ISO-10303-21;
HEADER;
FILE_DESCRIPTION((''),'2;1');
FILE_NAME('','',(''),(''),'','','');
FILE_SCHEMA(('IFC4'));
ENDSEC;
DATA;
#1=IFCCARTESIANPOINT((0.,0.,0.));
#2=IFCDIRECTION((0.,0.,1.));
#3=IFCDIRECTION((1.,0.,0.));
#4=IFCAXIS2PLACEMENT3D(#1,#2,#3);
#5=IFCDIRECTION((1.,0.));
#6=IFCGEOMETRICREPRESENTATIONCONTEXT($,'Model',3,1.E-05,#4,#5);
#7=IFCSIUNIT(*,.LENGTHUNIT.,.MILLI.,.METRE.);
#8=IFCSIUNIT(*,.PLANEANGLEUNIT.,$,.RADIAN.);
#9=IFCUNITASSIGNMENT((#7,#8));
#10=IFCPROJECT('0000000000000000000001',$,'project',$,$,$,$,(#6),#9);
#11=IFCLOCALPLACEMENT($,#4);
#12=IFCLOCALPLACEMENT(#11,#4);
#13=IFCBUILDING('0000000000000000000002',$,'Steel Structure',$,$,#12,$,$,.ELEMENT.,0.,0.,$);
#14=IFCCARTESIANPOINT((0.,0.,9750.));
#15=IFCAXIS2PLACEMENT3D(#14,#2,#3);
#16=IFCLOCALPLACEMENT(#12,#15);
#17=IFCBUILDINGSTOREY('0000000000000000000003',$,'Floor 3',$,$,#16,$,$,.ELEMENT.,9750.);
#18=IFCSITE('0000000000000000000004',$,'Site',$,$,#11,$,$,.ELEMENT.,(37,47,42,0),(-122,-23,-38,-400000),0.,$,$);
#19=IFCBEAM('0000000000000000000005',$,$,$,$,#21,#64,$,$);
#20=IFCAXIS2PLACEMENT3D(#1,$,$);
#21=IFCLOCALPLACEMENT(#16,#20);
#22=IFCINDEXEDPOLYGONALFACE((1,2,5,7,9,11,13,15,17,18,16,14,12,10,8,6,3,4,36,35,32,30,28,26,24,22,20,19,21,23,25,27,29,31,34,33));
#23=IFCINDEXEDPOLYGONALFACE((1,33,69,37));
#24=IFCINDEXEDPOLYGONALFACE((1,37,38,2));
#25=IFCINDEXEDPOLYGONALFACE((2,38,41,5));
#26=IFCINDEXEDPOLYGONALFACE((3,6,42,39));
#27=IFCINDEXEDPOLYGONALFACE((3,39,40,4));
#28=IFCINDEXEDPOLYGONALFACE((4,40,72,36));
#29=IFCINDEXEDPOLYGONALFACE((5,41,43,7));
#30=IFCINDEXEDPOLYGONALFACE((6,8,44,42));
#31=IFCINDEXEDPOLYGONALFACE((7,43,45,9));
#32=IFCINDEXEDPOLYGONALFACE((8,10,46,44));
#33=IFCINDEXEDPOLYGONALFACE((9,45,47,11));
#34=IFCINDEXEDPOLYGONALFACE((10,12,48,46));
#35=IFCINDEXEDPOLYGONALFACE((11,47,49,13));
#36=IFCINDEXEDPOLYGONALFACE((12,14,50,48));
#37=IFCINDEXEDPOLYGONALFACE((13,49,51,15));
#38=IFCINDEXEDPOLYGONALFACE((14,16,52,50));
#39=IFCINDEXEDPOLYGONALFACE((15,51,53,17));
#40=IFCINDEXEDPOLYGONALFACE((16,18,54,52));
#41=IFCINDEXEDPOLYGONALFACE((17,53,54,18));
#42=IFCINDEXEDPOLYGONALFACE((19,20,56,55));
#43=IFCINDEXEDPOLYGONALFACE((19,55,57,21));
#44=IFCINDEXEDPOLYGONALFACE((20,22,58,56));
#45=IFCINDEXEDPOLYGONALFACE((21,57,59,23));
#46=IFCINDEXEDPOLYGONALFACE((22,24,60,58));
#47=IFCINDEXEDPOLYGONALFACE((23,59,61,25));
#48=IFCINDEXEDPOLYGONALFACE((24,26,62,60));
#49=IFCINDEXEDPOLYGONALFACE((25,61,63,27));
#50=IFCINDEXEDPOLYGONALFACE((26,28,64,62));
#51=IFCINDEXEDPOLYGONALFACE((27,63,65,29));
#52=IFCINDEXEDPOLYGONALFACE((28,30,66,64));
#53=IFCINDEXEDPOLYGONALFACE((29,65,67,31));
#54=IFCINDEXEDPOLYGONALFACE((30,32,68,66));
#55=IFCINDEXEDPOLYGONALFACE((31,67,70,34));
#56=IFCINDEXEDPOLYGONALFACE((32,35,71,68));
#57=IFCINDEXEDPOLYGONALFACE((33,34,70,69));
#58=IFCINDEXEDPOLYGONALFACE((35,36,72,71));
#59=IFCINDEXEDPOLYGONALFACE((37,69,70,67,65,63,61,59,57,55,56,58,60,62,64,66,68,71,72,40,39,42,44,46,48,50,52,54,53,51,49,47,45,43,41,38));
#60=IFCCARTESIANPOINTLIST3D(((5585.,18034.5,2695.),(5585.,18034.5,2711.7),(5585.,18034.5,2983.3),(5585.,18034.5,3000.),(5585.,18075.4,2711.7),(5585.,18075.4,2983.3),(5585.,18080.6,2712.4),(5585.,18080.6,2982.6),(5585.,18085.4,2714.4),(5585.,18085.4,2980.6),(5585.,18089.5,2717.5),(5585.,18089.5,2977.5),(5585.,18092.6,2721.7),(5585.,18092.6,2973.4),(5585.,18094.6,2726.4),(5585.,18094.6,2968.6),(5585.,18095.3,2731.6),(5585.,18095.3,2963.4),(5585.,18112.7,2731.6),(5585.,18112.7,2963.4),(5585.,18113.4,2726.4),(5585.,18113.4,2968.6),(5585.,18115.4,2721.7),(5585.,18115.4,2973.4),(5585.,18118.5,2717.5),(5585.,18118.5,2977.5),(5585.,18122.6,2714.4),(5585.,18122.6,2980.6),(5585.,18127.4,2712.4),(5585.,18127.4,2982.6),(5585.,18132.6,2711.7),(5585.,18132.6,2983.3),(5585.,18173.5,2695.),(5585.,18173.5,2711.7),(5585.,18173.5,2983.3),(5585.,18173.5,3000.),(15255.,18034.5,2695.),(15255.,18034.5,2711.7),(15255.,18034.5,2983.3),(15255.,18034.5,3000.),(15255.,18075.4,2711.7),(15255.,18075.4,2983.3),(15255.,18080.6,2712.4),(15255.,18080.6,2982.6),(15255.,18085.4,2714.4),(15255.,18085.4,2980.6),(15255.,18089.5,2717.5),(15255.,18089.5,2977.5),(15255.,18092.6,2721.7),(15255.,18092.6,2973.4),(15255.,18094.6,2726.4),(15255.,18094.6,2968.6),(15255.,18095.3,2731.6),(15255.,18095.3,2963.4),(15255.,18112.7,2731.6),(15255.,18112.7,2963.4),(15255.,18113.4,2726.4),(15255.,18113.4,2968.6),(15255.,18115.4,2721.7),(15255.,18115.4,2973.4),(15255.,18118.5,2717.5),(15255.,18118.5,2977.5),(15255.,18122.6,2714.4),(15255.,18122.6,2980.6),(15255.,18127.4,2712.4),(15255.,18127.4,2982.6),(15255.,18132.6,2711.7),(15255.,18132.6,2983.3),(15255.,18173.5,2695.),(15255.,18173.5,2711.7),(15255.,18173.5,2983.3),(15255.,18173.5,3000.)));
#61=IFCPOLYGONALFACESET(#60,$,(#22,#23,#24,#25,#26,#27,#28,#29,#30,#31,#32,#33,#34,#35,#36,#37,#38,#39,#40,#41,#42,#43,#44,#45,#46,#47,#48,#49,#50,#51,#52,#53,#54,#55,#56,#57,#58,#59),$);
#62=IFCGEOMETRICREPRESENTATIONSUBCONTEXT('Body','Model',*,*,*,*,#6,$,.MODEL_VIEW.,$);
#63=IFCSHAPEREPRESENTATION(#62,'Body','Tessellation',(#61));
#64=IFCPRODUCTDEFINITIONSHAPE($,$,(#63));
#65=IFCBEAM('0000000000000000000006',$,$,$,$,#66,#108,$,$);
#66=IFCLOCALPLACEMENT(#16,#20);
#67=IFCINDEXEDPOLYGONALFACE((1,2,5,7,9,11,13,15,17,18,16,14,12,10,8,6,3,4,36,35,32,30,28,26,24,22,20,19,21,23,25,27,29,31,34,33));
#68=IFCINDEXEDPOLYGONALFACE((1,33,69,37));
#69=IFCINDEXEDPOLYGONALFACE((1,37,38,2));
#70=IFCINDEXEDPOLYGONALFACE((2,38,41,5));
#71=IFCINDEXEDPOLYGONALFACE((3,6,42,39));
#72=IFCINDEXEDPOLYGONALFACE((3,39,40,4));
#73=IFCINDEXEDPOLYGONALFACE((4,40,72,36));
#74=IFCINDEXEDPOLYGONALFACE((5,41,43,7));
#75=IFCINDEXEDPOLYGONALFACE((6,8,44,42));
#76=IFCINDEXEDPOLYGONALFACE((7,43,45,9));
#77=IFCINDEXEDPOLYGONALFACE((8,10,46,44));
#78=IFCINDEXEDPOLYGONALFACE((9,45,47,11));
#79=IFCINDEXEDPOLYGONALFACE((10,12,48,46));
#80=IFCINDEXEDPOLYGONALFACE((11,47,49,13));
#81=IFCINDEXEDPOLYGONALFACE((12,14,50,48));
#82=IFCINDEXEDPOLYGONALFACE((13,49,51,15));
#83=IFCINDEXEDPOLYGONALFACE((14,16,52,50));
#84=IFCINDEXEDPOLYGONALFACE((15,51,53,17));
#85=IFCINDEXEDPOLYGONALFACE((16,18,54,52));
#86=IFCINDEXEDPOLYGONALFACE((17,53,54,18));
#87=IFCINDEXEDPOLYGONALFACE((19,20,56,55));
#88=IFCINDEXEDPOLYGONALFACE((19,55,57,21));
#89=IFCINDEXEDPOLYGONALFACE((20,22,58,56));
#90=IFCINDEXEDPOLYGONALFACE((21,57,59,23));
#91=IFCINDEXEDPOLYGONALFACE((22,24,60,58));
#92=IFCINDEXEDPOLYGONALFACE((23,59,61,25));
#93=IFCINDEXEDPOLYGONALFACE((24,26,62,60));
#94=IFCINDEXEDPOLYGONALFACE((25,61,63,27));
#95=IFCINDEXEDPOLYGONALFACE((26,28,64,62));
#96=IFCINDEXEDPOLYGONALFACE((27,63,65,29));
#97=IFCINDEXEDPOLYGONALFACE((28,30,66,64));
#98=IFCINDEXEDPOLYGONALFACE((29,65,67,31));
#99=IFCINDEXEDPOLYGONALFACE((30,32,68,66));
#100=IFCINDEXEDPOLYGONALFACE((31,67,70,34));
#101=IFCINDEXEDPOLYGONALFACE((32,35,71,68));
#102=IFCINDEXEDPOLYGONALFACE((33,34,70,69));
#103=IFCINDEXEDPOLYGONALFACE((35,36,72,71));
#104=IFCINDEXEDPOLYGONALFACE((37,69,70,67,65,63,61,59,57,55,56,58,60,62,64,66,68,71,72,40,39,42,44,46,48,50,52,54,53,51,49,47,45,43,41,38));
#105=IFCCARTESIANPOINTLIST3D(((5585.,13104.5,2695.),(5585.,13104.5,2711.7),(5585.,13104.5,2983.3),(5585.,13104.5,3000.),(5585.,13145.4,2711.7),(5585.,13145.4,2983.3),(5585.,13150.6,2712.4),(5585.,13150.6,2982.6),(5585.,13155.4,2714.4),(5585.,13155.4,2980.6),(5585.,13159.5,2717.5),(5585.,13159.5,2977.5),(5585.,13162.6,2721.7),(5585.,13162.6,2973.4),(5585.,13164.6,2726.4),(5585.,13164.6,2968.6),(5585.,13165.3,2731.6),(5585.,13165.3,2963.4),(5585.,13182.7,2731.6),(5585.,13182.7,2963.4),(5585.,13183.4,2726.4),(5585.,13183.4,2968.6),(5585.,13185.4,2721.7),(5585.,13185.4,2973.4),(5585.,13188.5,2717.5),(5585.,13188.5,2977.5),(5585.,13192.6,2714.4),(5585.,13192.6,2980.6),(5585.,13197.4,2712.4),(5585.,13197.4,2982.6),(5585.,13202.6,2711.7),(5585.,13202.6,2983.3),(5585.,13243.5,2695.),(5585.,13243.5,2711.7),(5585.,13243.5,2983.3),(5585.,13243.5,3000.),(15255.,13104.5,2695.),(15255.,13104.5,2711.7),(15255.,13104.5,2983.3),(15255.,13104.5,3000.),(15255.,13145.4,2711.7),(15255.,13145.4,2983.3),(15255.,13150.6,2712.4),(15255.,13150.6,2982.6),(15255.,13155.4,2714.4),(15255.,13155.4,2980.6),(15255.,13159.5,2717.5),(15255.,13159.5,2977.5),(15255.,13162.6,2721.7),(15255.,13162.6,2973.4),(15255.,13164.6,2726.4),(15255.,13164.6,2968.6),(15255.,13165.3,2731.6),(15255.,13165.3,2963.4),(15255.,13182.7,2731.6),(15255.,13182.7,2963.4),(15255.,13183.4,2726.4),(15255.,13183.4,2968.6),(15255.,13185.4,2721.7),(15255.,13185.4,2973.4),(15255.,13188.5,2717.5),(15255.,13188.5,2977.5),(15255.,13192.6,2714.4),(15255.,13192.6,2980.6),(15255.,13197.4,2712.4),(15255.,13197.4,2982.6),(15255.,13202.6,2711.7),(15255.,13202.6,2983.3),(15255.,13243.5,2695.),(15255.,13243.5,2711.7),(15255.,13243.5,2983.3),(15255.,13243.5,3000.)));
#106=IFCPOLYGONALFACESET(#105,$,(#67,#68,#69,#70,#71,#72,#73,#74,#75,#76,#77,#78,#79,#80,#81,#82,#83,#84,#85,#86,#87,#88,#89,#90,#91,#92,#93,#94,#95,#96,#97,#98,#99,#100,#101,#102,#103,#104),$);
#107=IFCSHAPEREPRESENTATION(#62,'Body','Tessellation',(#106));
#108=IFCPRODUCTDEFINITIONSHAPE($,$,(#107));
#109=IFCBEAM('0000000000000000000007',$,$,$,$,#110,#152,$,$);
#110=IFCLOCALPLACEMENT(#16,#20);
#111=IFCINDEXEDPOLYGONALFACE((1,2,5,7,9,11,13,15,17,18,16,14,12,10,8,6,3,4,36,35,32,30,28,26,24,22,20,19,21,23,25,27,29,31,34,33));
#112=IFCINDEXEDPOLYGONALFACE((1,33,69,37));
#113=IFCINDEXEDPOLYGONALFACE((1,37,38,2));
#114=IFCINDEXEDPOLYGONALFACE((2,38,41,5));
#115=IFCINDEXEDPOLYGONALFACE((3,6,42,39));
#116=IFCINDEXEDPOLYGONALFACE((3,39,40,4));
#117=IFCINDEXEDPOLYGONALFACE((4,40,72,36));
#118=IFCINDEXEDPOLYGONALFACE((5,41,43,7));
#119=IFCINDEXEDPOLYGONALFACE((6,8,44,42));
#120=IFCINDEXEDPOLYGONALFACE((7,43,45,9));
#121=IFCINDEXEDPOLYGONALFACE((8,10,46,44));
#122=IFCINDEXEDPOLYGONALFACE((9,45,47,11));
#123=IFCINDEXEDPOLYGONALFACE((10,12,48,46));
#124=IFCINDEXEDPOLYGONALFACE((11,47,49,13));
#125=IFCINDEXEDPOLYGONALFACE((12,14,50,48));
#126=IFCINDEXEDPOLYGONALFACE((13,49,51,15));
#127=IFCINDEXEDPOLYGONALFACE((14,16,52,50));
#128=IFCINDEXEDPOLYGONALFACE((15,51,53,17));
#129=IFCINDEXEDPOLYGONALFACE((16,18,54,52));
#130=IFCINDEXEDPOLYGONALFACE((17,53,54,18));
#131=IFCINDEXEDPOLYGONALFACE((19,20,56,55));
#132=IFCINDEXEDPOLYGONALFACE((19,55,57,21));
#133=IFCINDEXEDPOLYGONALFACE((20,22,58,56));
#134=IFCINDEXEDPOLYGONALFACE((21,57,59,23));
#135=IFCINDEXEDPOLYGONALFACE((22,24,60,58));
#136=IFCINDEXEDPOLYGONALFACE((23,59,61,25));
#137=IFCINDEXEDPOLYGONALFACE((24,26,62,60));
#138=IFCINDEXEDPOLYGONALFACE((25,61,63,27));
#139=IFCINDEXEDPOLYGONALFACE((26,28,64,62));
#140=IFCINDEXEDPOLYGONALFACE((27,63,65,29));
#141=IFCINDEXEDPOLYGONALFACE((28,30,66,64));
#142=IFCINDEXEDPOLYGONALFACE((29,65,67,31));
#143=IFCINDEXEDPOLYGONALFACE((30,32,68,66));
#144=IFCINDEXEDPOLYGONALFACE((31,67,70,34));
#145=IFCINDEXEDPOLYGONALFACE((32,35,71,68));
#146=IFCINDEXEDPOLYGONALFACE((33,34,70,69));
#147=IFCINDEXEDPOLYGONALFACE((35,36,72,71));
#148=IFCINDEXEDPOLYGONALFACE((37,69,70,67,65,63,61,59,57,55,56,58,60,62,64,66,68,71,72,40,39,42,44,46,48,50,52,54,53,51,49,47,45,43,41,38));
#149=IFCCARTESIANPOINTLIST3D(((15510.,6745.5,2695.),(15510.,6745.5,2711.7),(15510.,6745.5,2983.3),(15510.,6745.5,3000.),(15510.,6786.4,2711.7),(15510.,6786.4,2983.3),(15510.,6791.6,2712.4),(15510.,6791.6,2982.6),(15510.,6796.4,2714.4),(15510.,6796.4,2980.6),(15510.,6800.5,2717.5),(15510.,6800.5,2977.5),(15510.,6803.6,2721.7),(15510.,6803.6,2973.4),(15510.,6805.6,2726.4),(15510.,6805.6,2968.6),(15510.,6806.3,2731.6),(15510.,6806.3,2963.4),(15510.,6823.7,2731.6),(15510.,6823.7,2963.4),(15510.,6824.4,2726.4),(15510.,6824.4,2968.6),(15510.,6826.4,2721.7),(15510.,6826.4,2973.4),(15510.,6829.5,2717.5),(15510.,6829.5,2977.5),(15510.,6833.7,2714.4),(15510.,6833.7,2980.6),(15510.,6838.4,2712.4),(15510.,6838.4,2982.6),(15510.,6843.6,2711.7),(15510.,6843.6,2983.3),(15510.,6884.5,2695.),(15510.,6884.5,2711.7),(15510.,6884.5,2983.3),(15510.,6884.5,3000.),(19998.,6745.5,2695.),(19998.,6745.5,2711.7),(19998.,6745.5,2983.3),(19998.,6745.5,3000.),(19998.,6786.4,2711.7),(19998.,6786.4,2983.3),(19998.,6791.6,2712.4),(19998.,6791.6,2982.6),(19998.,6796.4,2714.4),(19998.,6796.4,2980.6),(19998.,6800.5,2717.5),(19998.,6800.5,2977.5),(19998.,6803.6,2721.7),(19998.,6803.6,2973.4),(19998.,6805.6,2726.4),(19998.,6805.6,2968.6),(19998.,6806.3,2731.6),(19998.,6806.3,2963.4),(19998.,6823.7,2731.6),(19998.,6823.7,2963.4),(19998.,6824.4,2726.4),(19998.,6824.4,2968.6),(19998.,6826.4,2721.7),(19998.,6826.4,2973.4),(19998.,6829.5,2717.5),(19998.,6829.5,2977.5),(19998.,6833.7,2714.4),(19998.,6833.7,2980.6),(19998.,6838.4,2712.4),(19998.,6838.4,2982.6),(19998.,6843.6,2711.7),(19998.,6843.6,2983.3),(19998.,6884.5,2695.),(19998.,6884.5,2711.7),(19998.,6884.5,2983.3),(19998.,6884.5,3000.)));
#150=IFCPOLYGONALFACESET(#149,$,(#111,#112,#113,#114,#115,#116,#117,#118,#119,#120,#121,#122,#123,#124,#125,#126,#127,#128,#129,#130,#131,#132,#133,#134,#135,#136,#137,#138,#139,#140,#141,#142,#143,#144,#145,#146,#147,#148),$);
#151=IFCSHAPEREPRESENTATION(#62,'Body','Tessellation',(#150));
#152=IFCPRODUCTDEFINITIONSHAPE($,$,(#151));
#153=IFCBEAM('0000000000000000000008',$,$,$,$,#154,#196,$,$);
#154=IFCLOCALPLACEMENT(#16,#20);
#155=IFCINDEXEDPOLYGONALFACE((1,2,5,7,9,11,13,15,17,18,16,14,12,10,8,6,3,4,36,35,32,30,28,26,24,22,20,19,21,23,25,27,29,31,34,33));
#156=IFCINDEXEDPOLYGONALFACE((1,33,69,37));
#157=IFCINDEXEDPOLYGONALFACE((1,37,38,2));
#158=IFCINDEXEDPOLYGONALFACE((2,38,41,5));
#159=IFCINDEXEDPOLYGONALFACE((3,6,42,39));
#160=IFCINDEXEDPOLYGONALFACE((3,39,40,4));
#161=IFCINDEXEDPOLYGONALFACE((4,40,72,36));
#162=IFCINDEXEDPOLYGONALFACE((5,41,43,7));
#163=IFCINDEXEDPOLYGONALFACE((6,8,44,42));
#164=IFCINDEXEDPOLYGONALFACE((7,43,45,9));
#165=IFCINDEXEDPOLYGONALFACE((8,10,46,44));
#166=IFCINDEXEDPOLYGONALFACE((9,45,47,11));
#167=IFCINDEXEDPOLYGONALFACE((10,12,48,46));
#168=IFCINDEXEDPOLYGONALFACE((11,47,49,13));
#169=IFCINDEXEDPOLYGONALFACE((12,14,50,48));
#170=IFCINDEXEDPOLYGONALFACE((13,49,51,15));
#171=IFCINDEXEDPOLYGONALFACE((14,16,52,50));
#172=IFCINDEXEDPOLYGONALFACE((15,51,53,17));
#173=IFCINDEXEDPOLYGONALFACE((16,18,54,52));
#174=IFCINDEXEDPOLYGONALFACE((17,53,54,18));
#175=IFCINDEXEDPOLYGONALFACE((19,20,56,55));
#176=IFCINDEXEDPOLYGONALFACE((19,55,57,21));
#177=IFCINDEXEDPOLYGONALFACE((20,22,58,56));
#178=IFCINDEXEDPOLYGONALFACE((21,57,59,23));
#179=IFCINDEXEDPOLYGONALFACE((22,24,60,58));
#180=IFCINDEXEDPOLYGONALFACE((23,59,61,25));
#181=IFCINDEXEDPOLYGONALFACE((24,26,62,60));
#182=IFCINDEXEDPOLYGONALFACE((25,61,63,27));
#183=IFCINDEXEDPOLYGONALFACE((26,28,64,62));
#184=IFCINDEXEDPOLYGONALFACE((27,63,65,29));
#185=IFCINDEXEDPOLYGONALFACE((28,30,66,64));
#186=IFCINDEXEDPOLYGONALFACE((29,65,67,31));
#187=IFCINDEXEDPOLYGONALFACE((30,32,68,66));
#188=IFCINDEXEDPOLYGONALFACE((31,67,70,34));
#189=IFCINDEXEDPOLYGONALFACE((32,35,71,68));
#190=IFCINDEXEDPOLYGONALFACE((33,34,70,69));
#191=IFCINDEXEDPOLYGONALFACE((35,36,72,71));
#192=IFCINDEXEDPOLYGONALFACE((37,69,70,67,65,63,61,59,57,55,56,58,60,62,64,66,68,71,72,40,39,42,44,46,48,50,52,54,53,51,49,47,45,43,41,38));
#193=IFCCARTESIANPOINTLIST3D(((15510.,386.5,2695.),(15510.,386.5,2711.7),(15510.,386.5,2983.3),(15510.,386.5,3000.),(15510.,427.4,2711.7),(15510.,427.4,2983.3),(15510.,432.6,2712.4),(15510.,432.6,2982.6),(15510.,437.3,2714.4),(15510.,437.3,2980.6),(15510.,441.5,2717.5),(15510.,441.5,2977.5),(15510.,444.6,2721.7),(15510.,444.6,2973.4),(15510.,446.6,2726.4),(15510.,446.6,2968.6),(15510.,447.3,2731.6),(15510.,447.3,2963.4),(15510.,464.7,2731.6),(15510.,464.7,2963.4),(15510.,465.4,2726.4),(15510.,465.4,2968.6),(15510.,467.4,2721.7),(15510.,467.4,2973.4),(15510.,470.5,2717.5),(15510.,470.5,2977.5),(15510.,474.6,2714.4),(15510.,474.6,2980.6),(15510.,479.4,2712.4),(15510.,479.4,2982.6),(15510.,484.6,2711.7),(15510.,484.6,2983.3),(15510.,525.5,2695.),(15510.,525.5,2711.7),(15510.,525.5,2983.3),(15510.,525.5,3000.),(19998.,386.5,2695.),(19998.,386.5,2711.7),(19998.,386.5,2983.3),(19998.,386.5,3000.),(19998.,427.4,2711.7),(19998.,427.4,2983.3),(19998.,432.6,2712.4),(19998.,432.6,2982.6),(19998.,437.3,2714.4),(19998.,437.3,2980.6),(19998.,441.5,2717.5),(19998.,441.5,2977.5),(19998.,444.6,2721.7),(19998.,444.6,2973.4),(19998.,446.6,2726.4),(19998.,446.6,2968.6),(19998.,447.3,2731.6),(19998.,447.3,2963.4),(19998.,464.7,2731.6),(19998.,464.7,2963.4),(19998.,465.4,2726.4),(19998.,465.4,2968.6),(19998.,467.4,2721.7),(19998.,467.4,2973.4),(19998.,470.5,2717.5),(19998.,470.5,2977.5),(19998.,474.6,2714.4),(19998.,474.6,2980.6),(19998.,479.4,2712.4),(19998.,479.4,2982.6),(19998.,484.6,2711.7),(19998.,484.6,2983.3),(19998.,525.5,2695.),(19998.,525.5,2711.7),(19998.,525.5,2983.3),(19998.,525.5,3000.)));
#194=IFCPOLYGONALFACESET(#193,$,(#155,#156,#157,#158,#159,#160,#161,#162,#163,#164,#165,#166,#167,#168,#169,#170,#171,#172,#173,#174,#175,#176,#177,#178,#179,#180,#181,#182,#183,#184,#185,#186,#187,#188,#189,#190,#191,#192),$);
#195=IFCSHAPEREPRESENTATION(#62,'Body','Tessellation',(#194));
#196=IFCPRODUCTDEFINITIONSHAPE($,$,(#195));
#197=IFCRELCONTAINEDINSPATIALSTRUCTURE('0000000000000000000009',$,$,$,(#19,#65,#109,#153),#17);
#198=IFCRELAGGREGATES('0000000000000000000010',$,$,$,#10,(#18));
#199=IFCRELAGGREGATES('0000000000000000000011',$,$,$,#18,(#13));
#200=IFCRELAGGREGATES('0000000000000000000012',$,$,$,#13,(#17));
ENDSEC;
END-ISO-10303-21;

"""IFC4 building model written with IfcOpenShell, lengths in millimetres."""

from ifc_helpers import new_model, si_unit, direction, frame, origin_with_axes, origin_2d_with_axis, place, context, subcontext, project, spatial, i_section, extrude, element, save


model = new_model("IFC4")

# Units and contexts
model_context = context("Model", 3, precision=1e-05, world=origin_with_axes(), true_north=direction((1.0, 0.0)))
body_context = subcontext(model_context, "Body", "Model", "MODEL_VIEW")
ifc_project = project(units=[si_unit("LENGTHUNIT", "METRE", prefix="MILLI"), si_unit("PLANEANGLEUNIT", "RADIAN")], contexts=[model_context])

# Site, building, storey
site_placement = place(None, origin_with_axes())
site = spatial("IfcSite", under=ifc_project, at=site_placement, Name="Site", CompositionType="ELEMENT", RefLatitude=(37, 47, 42, 0), RefLongitude=(-122, -23, -38, -400000), RefElevation=0.0)
building_placement = place(site_placement, origin_with_axes())
building = spatial("IfcBuilding", under=site, at=building_placement, Name="Steel Structure", CompositionType="ELEMENT", ElevationOfRefHeight=0.0, ElevationOfTerrain=0.0)
storey_placement = place(building_placement, frame((0.0, 0.0, 9750.0), z_axis=(0.0, 0.0, 1.0), x_axis=(1.0, 0.0, 0.0)))
storey = spatial("IfcBuildingStorey", under=building, at=storey_placement, Name="Floor 3", CompositionType="ELEMENT", Elevation=9750.0)

# Beams
for number, where, z_axis, x_axis in (
    (1, (5585.0, 18104.0, 2695.0), (1.0, 0.0, 0.0), (0.0, 1.0, 0.0)),
    (2, (5585.0, 13174.0, 2695.0), (1.0, 0.0, 0.0), (0.0, 1.0, 0.0)),
):
    element("IfcBeam", number, at=place(storey_placement, frame(where, z_axis=z_axis, x_axis=x_axis)), inside=storey, context=body_context, shape_type="SweptSolid", body=[
        extrude(i_section(OverallWidth=139.0, OverallDepth=305.0, WebThickness=17.4, FlangeThickness=16.7, FilletRadius=19.9, at=origin_2d_with_axis()), frame((0.0, 152.5, 0.0), z_axis=(0.0, 0.0, 1.0), x_axis=(1.0, 0.0, 0.0)), (0.0, 0.0, 1.0), 9670.0),
    ])
beam_1_placement = place(storey_placement, frame((19998.0, 6815.0, 2695.0), z_axis=(-1.0, 0.0, 0.0), x_axis=(0.0, -1.0, 0.0)))
element("IfcBeam", 3, at=beam_1_placement, inside=storey, context=body_context, shape_type="SweptSolid", body=[
    extrude(i_section(OverallWidth=139.0, OverallDepth=305.0, WebThickness=17.4, FlangeThickness=16.7, FilletRadius=19.9, at=origin_2d_with_axis()), frame((0.0, 152.5, 0.0), z_axis=(0.0, 0.0, 1.0), x_axis=(1.0, 0.0, 0.0)), (0.0, 0.0, 1.0), 4488.0),
])
beam_2_placement = place(storey_placement, frame((15510.0, 456.0, 2695.0), z_axis=(1.0, 0.0, 0.0), x_axis=(0.0, 1.0, 0.0)))
element("IfcBeam", 4, at=beam_2_placement, inside=storey, context=body_context, shape_type="SweptSolid", body=[
    extrude(i_section(OverallWidth=139.0, OverallDepth=305.0, WebThickness=17.4, FlangeThickness=16.7, FilletRadius=19.9, at=origin_2d_with_axis()), frame((0.0, 152.5, 0.0), z_axis=(0.0, 0.0, 1.0), x_axis=(1.0, 0.0, 0.0)), (0.0, 0.0, 1.0), 4488.0),
])

save(model, "model.ifc")
